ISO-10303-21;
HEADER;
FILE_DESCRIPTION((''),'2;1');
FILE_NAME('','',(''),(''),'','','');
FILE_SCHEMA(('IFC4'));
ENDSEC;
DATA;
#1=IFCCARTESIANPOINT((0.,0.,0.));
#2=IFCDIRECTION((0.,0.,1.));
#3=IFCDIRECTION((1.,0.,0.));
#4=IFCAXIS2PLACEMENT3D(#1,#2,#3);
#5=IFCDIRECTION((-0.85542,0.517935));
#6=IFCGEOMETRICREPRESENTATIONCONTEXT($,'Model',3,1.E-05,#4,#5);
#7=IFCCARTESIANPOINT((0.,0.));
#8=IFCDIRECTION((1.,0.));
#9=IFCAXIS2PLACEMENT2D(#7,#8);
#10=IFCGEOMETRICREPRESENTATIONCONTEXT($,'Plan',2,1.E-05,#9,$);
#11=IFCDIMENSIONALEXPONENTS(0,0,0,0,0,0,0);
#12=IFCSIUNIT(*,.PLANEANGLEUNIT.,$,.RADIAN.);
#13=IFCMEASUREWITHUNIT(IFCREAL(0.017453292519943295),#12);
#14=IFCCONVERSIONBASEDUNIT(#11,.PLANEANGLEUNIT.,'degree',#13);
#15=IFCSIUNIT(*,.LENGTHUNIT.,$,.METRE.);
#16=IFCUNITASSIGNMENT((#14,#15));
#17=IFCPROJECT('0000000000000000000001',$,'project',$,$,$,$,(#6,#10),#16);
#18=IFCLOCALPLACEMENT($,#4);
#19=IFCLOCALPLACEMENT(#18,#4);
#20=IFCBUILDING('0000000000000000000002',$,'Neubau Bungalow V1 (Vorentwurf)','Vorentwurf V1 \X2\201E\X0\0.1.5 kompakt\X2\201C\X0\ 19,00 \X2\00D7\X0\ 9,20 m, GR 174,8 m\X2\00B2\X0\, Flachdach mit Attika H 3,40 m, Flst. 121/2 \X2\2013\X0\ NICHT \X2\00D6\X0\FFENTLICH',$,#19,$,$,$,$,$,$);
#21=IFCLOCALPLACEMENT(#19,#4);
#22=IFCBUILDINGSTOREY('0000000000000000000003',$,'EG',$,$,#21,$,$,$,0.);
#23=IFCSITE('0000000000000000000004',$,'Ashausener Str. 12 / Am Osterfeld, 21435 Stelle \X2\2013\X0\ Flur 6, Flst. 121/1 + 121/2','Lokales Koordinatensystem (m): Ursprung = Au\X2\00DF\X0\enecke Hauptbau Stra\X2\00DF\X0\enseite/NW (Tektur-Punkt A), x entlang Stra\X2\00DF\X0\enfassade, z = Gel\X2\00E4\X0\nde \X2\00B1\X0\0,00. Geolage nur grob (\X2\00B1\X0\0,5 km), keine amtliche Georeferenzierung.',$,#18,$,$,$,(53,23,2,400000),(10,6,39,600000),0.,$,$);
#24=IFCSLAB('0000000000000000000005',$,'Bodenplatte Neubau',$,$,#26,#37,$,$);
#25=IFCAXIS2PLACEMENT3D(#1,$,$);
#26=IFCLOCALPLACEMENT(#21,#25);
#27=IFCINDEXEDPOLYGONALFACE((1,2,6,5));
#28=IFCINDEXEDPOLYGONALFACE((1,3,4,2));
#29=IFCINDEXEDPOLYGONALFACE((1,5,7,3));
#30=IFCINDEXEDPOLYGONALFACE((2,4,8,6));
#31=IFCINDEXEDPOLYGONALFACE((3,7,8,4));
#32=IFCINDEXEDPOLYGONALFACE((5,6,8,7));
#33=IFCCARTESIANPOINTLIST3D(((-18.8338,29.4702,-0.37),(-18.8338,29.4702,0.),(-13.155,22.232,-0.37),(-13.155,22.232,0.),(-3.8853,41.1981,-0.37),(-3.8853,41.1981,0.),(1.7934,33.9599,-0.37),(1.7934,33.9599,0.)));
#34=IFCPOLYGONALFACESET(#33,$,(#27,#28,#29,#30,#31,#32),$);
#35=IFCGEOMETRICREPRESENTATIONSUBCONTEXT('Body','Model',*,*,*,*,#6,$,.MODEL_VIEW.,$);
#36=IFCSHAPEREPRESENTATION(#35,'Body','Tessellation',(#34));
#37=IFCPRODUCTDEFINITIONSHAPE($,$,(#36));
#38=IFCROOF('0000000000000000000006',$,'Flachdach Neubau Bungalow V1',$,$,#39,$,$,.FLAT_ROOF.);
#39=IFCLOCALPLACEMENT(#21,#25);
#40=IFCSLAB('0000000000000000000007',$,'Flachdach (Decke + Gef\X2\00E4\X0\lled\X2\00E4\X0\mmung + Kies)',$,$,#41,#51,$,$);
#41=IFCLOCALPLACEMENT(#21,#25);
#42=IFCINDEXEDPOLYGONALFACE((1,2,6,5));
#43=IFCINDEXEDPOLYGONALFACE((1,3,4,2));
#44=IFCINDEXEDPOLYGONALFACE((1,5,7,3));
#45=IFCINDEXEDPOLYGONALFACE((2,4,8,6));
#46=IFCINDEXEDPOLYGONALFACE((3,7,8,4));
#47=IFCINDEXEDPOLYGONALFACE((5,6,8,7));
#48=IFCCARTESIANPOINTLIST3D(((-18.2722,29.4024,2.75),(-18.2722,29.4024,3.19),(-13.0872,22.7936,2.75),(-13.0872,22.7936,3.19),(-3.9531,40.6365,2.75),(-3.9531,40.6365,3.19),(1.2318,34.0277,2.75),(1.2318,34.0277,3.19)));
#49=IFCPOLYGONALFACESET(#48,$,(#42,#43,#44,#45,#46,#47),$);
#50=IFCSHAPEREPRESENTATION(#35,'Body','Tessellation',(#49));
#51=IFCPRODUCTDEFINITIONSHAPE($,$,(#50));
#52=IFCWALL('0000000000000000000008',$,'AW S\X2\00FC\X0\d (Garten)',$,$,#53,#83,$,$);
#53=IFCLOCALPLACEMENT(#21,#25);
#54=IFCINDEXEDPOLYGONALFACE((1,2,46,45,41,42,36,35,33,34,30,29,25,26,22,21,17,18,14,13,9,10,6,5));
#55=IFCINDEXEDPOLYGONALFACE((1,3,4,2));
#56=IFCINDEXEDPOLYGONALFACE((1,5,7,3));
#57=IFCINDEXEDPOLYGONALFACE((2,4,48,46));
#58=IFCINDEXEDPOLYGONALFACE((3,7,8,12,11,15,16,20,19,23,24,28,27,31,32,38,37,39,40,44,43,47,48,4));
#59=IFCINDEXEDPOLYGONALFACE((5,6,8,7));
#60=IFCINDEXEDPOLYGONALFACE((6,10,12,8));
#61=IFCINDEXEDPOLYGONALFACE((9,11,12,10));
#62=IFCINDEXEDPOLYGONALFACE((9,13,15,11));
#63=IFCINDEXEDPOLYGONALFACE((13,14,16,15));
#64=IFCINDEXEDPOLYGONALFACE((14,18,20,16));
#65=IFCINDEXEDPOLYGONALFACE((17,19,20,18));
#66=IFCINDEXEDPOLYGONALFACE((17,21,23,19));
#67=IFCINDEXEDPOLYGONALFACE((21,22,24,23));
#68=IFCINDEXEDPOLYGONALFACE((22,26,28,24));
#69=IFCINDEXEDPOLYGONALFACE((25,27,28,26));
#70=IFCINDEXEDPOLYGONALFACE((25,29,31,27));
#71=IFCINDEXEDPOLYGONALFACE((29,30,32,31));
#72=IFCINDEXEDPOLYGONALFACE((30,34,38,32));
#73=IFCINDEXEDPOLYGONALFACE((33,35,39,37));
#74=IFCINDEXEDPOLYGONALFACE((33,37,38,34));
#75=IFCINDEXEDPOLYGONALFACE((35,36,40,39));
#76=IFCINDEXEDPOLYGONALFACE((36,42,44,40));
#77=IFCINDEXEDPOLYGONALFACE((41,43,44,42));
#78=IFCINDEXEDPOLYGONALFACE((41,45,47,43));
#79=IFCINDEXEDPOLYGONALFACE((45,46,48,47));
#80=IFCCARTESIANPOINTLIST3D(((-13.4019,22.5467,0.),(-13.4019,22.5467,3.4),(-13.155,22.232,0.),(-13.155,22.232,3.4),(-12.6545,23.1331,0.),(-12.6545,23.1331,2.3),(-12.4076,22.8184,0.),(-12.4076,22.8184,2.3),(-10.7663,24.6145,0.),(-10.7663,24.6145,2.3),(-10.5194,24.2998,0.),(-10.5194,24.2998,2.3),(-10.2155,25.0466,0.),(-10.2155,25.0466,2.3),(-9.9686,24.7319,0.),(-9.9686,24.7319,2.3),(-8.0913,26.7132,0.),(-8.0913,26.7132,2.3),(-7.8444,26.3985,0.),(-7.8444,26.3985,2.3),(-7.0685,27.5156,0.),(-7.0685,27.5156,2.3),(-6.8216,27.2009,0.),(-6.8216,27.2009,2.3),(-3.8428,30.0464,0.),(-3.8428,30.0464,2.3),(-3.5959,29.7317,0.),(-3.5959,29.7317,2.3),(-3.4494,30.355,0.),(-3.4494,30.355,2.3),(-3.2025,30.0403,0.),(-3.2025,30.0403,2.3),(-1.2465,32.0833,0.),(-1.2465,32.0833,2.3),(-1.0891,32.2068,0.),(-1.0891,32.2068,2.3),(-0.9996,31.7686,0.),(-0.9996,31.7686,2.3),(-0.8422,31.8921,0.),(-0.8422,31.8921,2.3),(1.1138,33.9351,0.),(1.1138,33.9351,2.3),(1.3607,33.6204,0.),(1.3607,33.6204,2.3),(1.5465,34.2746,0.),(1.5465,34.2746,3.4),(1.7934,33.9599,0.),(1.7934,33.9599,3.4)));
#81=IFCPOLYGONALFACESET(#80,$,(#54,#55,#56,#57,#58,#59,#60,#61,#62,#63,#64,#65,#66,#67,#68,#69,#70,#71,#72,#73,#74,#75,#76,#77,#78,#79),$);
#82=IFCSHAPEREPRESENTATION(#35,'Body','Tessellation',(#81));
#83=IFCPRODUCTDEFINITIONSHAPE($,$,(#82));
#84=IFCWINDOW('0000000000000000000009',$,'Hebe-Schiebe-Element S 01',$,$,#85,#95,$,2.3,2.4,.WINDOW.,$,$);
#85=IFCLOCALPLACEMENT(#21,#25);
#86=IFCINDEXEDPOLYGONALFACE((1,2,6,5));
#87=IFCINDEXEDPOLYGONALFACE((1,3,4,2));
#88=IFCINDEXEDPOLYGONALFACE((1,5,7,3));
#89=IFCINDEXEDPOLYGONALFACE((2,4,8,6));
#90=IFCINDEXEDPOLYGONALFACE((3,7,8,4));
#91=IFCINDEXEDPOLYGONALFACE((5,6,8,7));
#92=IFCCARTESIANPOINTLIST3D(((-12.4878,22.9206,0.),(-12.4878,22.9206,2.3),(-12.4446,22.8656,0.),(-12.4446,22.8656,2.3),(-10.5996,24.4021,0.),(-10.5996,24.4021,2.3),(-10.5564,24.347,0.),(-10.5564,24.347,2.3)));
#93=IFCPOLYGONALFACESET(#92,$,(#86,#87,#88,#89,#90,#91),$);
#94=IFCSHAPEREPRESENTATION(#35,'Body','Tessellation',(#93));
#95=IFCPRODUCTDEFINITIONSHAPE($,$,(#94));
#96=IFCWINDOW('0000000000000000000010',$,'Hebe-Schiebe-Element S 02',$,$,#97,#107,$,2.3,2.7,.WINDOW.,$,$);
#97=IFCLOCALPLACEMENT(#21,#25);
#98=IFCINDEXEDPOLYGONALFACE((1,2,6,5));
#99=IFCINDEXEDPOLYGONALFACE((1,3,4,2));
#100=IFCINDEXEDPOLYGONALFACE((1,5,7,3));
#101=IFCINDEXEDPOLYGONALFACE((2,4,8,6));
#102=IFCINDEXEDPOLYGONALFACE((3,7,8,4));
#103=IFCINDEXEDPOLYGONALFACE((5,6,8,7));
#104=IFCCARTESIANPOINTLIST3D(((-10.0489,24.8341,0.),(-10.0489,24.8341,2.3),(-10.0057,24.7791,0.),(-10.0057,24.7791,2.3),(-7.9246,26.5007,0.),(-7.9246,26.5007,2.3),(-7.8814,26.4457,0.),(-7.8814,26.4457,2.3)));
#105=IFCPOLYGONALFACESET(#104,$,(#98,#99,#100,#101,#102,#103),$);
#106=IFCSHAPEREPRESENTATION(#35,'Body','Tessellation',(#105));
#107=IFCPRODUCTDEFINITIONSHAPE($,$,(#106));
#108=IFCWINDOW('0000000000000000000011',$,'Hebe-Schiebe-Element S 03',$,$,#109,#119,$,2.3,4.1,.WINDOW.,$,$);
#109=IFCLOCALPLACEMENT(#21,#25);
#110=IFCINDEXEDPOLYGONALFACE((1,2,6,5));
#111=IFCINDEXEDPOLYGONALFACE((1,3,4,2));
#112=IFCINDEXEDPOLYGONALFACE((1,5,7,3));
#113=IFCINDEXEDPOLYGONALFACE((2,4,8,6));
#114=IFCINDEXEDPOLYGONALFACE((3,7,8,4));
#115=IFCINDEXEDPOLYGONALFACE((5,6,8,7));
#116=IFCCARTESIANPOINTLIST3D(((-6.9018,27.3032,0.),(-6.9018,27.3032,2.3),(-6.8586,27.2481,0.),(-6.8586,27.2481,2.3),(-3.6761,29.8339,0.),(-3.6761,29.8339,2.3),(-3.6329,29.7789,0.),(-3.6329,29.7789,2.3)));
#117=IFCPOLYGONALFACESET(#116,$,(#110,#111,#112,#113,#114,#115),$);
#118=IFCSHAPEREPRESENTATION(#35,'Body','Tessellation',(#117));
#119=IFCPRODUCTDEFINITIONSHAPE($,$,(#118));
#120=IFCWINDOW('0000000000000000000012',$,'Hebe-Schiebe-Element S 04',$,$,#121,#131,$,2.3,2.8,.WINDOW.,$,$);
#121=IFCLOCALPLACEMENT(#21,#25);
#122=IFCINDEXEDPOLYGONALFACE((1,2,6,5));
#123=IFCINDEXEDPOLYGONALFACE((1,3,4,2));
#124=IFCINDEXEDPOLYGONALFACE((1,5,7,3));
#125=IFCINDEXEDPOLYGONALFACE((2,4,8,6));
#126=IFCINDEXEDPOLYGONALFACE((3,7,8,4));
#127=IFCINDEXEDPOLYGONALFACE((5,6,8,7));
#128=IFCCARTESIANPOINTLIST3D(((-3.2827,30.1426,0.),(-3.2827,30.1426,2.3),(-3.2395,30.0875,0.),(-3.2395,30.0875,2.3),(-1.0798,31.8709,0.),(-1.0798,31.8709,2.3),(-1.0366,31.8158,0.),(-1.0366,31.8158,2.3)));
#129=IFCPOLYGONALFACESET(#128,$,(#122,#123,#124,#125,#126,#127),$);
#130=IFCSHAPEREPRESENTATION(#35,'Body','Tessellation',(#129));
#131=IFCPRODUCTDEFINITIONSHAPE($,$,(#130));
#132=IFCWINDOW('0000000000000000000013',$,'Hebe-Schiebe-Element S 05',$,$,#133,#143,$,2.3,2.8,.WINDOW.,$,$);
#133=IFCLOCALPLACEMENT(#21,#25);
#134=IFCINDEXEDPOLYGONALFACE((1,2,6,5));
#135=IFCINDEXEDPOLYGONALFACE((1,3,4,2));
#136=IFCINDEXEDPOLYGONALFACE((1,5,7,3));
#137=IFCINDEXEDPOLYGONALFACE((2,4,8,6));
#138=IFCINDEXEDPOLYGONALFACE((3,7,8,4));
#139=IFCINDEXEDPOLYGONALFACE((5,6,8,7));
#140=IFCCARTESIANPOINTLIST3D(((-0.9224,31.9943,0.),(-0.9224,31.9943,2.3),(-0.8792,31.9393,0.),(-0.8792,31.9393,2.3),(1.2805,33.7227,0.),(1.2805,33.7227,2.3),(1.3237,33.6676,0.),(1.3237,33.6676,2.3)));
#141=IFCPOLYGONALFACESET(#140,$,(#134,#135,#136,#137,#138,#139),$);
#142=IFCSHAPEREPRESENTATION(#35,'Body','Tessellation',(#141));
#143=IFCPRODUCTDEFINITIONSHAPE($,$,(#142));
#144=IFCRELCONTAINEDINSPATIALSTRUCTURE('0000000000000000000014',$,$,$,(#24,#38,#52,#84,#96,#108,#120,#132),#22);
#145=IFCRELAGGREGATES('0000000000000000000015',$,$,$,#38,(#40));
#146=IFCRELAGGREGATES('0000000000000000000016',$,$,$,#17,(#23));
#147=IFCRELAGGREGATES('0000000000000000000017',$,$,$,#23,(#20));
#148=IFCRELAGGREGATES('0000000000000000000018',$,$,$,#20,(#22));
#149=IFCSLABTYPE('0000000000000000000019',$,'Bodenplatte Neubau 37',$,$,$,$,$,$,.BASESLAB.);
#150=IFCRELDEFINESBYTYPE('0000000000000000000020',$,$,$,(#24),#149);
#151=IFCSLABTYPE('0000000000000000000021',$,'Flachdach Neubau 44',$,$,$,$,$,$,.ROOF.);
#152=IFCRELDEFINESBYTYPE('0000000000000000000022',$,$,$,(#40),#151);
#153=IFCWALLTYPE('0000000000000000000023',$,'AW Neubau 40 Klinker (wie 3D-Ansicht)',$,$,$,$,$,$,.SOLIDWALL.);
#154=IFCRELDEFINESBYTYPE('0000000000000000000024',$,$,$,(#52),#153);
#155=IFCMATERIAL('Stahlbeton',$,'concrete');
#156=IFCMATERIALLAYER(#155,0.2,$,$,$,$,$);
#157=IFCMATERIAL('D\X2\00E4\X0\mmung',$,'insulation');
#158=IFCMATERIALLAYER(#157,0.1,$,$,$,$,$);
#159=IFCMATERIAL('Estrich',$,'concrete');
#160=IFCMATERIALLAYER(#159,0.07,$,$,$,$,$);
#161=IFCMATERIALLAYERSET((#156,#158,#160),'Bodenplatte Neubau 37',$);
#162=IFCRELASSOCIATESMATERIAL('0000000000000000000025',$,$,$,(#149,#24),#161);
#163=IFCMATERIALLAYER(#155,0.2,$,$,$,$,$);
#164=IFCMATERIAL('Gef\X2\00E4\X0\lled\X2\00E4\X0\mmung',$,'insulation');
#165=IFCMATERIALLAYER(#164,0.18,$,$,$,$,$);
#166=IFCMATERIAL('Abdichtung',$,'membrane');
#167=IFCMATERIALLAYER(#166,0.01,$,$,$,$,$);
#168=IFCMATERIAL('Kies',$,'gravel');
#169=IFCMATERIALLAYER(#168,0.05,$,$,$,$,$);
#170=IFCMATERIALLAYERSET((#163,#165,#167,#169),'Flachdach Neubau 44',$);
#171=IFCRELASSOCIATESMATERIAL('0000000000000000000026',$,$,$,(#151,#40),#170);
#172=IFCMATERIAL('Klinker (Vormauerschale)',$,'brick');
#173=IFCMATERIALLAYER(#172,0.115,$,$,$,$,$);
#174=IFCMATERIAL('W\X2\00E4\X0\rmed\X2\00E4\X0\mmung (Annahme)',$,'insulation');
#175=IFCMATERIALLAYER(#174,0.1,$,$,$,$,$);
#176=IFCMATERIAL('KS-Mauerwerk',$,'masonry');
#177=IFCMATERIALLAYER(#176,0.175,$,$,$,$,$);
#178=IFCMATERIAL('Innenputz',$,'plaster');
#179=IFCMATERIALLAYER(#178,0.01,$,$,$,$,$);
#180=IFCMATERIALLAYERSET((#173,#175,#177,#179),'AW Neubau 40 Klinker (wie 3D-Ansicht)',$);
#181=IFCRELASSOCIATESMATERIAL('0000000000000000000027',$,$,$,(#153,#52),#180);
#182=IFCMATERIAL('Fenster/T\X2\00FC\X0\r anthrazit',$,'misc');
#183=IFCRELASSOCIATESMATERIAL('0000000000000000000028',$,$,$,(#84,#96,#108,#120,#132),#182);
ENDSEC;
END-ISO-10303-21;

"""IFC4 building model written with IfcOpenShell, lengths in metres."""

from ifc_helpers import new_model, entity, si_unit, converted_unit, direction, frame, origin_with_axes, origin_2d_with_axis, place, context, subcontext, project, spatial, polyline, indexed_curve, outline, extrude, material, layer, layer_set, layer_usage, type_object, element, fill, aggregate, save


model = new_model("IFC4")

# Units and contexts
model_context = context("Model", 3, precision=1e-05, world=origin_with_axes(), true_north=direction((-0.85542, 0.517935)))
plan_context = context("Plan", 2, precision=1e-05, world=origin_2d_with_axis())
body_context = subcontext(model_context, "Body", "Model", "MODEL_VIEW")
ifc_project = project(units=[converted_unit("PLANEANGLEUNIT", "degree", entity("IfcReal", 0.017453292519943295), si_unit("PLANEANGLEUNIT", "RADIAN"), dimensions=[0, 0, 0, 0, 0, 0, 0]), si_unit("LENGTHUNIT", "METRE")], contexts=[model_context, plan_context])

# Site, building, storey
site_placement = place(None, origin_with_axes())
site = spatial("IfcSite", under=ifc_project, at=site_placement, Name="Ashausener Str. 12 / Am Osterfeld, 21435 Stelle – Flur 6, Flst. 121/1 + 121/2", Description="Lokales Koordinatensystem (m): Ursprung = Außenecke Hauptbau Straßenseite/NW (Tektur-Punkt A), x entlang Straßenfassade, z = Gelände ±0,00. Geolage nur grob (±0,5 km), keine amtliche Georeferenzierung.", RefLatitude=(53, 23, 2, 400000), RefLongitude=(10, 6, 39, 600000), RefElevation=0.0)
building_placement = place(site_placement, origin_with_axes())
building = spatial("IfcBuilding", under=site, at=building_placement, Name="Neubau Bungalow V1 (Vorentwurf)", Description="Vorentwurf V1 „0.1.5 kompakt“ 19,00 × 9,20 m, GR 174,8 m², Flachdach mit Attika H 3,40 m, Flst. 121/2 – NICHT ÖFFENTLICH")
storey_placement = place(building_placement, origin_with_axes())
storey = spatial("IfcBuildingStorey", under=building, at=storey_placement, Name="EG", Elevation=0.0)

# Slab
ifc_material_1 = material(Name="Stahlbeton", Category="concrete")
ifc_layer_1 = layer(ifc_material_1, 0.2)
ifc_material_2 = material(Name="Dämmung", Category="insulation")
ifc_layer_2 = layer(ifc_material_2, 0.1)
ifc_material_3 = material(Name="Estrich", Category="concrete")
ifc_layer_3 = layer(ifc_material_3, 0.07)
ifc_layer_set_1 = layer_set([ifc_layer_1, ifc_layer_2, ifc_layer_3], Name="Bodenplatte Neubau 37")
ifc_layer_usage_1 = layer_usage(ifc_layer_set_1, "AXIS3", "POSITIVE", 0.0)
slab_type_1 = type_object("IfcSlabType", Name="Bodenplatte Neubau 37", PredefinedType="BASESLAB", material=ifc_layer_set_1)
slab_1_placement = place(storey_placement, origin_with_axes())
element("IfcSlab", 1, at=slab_1_placement, inside=storey, type_object=slab_type_1, material=ifc_layer_usage_1, Name="Bodenplatte Neubau", context=body_context, shape_type="SweptSolid", body=[
    extrude(outline(polyline([(-13.155, 22.232), (1.7934, 33.9599), (-3.8853, 41.1981), (-18.8338, 29.4702), (-13.155, 22.232)])), frame((0.0, 0.0, -0.37)), (0.0, 0.0, 1.0), 0.37),
])

# Roof, slab
roof_placement = place(storey_placement, origin_with_axes())
roof = element("IfcRoof", 2, at=roof_placement, inside=storey, Name="Flachdach Neubau Bungalow V1", PredefinedType="FLAT_ROOF")
ifc_layer_4 = layer(ifc_material_1, 0.2)
ifc_material_4 = material(Name="Gefälledämmung", Category="insulation")
ifc_layer_5 = layer(ifc_material_4, 0.18)
ifc_material_5 = material(Name="Abdichtung", Category="membrane")
ifc_layer_6 = layer(ifc_material_5, 0.01)
ifc_material_6 = material(Name="Kies", Category="gravel")
ifc_layer_7 = layer(ifc_material_6, 0.05)
ifc_layer_set_2 = layer_set([ifc_layer_4, ifc_layer_5, ifc_layer_6, ifc_layer_7], Name="Flachdach Neubau 44")
ifc_layer_usage_2 = layer_usage(ifc_layer_set_2, "AXIS3", "POSITIVE", 0.0)
slab_type_2 = type_object("IfcSlabType", Name="Flachdach Neubau 44", PredefinedType="ROOF", material=ifc_layer_set_2)
slab_2_placement = place(roof_placement, origin_with_axes())
slab_2 = element("IfcSlab", 3, at=slab_2_placement, type_object=slab_type_2, material=ifc_layer_usage_2, Name="Flachdach (Decke + Gefälledämmung + Kies)", context=body_context, shape_type="SweptSolid", body=[
    extrude(outline(polyline([(-13.0872, 22.7936), (1.2318, 34.0277), (-3.9531, 40.6365), (-18.2722, 29.4024), (-13.0872, 22.7936)])), frame((0.0, 0.0, 2.75)), (0.0, 0.0, 1.0), 0.44),
])
aggregate(roof, [slab_2])

# Wall, openings, windows
ifc_material_7 = material(Name="Klinker (Vormauerschale)", Category="brick")
ifc_layer_8 = layer(ifc_material_7, 0.115)
ifc_material_8 = material(Name="Wärmedämmung (Annahme)", Category="insulation")
ifc_layer_9 = layer(ifc_material_8, 0.1)
ifc_material_9 = material(Name="KS-Mauerwerk", Category="masonry")
ifc_layer_10 = layer(ifc_material_9, 0.175)
ifc_material_10 = material(Name="Innenputz", Category="plaster")
ifc_layer_11 = layer(ifc_material_10, 0.01)
ifc_layer_set_3 = layer_set([ifc_layer_8, ifc_layer_9, ifc_layer_10, ifc_layer_11], Name="AW Neubau 40 Klinker (wie 3D-Ansicht)")
ifc_layer_usage_3 = layer_usage(ifc_layer_set_3, "AXIS2", "POSITIVE", 0.0)
wall_type_1 = type_object("IfcWallType", Name="AW Neubau 40 Klinker (wie 3D-Ansicht)", PredefinedType="SOLIDWALL", material=ifc_layer_set_3)
wall_1_placement = place(storey_placement, frame((-13.155, 22.232, 0.0), z_axis=(0.0, 0.0, 1.0), x_axis=(0.786761, 0.617258, 0.0)))
wall_1 = element("IfcWall", 4, at=wall_1_placement, inside=storey, type_object=wall_type_1, material=ifc_layer_usage_3, Name="AW Süd (Garten)", context=body_context, shape_type="SweptSolid", body=[
    extrude(outline(indexed_curve([(0.0, 0.0), (0.0, 0.4), (19.0, 0.4), (19.0, 0.0), (0.0, 0.0)], self_intersect=False)), origin_with_axes(), (0.0, 0.0, 1.0), 3.4),
])
opening_1_placement = place(wall_1_placement, frame((0.95, -0.1, 0.0), z_axis=(0.0, 0.0, 1.0), x_axis=(1.0, 0.0, 0.0)))
opening_1 = element("IfcOpeningElement", 5, at=opening_1_placement, cuts=wall_1, context=body_context, shape_type="SweptSolid", body=[
    extrude(outline(indexed_curve([(0.0, 0.0), (0.0, 0.6), (2.4, 0.6), (2.4, 0.0), (0.0, 0.0)], self_intersect=False)), origin_with_axes(), (0.0, 0.0, 1.0), 2.3),
])
opening_2_placement = place(wall_1_placement, frame((4.05, -0.1, 0.0), z_axis=(0.0, 0.0, 1.0), x_axis=(1.0, 0.0, 0.0)))
opening_2 = element("IfcOpeningElement", 6, at=opening_2_placement, cuts=wall_1, context=body_context, shape_type="SweptSolid", body=[
    extrude(outline(indexed_curve([(0.0, 0.0), (0.0, 0.6), (2.7, 0.6), (2.7, 0.0), (0.0, 0.0)], self_intersect=False)), origin_with_axes(), (0.0, 0.0, 1.0), 2.3),
])
opening_3_placement = place(wall_1_placement, frame((8.05, -0.1, 0.0), z_axis=(0.0, 0.0, 1.0), x_axis=(1.0, 0.0, 0.0)))
opening_3 = element("IfcOpeningElement", 7, at=opening_3_placement, cuts=wall_1, context=body_context, shape_type="SweptSolid", body=[
    extrude(outline(indexed_curve([(0.0, 0.0), (0.0, 0.6), (4.1, 0.6), (4.1, 0.0), (0.0, 0.0)], self_intersect=False)), origin_with_axes(), (0.0, 0.0, 1.0), 2.3),
])
opening_4_placement = place(wall_1_placement, frame((12.65, -0.1, 0.0), z_axis=(0.0, 0.0, 1.0), x_axis=(1.0, 0.0, 0.0)))
opening_4 = element("IfcOpeningElement", 8, at=opening_4_placement, cuts=wall_1, context=body_context, shape_type="SweptSolid", body=[
    extrude(outline(indexed_curve([(0.0, 0.0), (0.0, 0.6), (2.8, 0.6), (2.8, 0.0), (0.0, 0.0)], self_intersect=False)), origin_with_axes(), (0.0, 0.0, 1.0), 2.3),
])
opening_5_placement = place(wall_1_placement, frame((15.65, -0.1, 0.0), z_axis=(0.0, 0.0, 1.0), x_axis=(1.0, 0.0, 0.0)))
opening_5 = element("IfcOpeningElement", 9, at=opening_5_placement, cuts=wall_1, context=body_context, shape_type="SweptSolid", body=[
    extrude(outline(indexed_curve([(0.0, 0.0), (0.0, 0.6), (2.8, 0.6), (2.8, 0.0), (0.0, 0.0)], self_intersect=False)), origin_with_axes(), (0.0, 0.0, 1.0), 2.3),
])
ifc_material_11 = material(Name="Fenster/Tür anthrazit", Category="misc")
window_1_placement = place(storey_placement, frame((-12.4446, 22.8656, 0.0), z_axis=(0.0, 0.0, 1.0), x_axis=(0.786761, 0.617258, 0.0)))
window_1 = element("IfcWindow", 10, at=window_1_placement, inside=storey, material=ifc_material_11, Name="Hebe-Schiebe-Element S 01", OverallHeight=2.3, OverallWidth=2.4, PredefinedType="WINDOW", context=body_context, shape_type="SweptSolid", body=[
    extrude(outline(indexed_curve([(0.0, 0.0), (0.0, 0.07), (2.4, 0.07), (2.4, 0.0), (0.0, 0.0)], self_intersect=False)), origin_with_axes(), (0.0, 0.0, 1.0), 2.3),
])
fill(opening_1, window_1)
window_2_placement = place(storey_placement, frame((-10.0057, 24.7791, 0.0), z_axis=(0.0, 0.0, 1.0), x_axis=(0.786761, 0.617258, 0.0)))
window_2 = element("IfcWindow", 11, at=window_2_placement, inside=storey, material=ifc_material_11, Name="Hebe-Schiebe-Element S 02", OverallHeight=2.3, OverallWidth=2.7, PredefinedType="WINDOW", context=body_context, shape_type="SweptSolid", body=[
    extrude(outline(indexed_curve([(0.0, 0.0), (0.0, 0.07), (2.7, 0.07), (2.7, 0.0), (0.0, 0.0)], self_intersect=False)), origin_with_axes(), (0.0, 0.0, 1.0), 2.3),
])
fill(opening_2, window_2)
window_3_placement = place(storey_placement, frame((-6.8586, 27.2481, 0.0), z_axis=(0.0, 0.0, 1.0), x_axis=(0.786761, 0.617258, 0.0)))
window_3 = element("IfcWindow", 12, at=window_3_placement, inside=storey, material=ifc_material_11, Name="Hebe-Schiebe-Element S 03", OverallHeight=2.3, OverallWidth=4.1, PredefinedType="WINDOW", context=body_context, shape_type="SweptSolid", body=[
    extrude(outline(indexed_curve([(0.0, 0.0), (0.0, 0.07), (4.1, 0.07), (4.1, 0.0), (0.0, 0.0)], self_intersect=False)), origin_with_axes(), (0.0, 0.0, 1.0), 2.3),
])
fill(opening_3, window_3)
window_4_placement = place(storey_placement, frame((-3.2395, 30.0875, 0.0), z_axis=(0.0, 0.0, 1.0), x_axis=(0.786761, 0.617258, 0.0)))
window_4 = element("IfcWindow", 13, at=window_4_placement, inside=storey, material=ifc_material_11, Name="Hebe-Schiebe-Element S 04", OverallHeight=2.3, OverallWidth=2.8, PredefinedType="WINDOW", context=body_context, shape_type="SweptSolid", body=[
    extrude(outline(indexed_curve([(0.0, 0.0), (0.0, 0.07), (2.8, 0.07), (2.8, 0.0), (0.0, 0.0)], self_intersect=False)), origin_with_axes(), (0.0, 0.0, 1.0), 2.3),
])
fill(opening_4, window_4)
window_5_placement = place(storey_placement, frame((-0.8792, 31.9393, 0.0), z_axis=(0.0, 0.0, 1.0), x_axis=(0.786761, 0.617258, 0.0)))
window_5 = element("IfcWindow", 14, at=window_5_placement, inside=storey, material=ifc_material_11, Name="Hebe-Schiebe-Element S 05", OverallHeight=2.3, OverallWidth=2.8, PredefinedType="WINDOW", context=body_context, shape_type="SweptSolid", body=[
    extrude(outline(indexed_curve([(0.0, 0.0), (0.0, 0.07), (2.8, 0.07), (2.8, 0.0), (0.0, 0.0)], self_intersect=False)), origin_with_axes(), (0.0, 0.0, 1.0), 2.3),
])
fill(opening_5, window_5)

save(model, "model.ifc")
